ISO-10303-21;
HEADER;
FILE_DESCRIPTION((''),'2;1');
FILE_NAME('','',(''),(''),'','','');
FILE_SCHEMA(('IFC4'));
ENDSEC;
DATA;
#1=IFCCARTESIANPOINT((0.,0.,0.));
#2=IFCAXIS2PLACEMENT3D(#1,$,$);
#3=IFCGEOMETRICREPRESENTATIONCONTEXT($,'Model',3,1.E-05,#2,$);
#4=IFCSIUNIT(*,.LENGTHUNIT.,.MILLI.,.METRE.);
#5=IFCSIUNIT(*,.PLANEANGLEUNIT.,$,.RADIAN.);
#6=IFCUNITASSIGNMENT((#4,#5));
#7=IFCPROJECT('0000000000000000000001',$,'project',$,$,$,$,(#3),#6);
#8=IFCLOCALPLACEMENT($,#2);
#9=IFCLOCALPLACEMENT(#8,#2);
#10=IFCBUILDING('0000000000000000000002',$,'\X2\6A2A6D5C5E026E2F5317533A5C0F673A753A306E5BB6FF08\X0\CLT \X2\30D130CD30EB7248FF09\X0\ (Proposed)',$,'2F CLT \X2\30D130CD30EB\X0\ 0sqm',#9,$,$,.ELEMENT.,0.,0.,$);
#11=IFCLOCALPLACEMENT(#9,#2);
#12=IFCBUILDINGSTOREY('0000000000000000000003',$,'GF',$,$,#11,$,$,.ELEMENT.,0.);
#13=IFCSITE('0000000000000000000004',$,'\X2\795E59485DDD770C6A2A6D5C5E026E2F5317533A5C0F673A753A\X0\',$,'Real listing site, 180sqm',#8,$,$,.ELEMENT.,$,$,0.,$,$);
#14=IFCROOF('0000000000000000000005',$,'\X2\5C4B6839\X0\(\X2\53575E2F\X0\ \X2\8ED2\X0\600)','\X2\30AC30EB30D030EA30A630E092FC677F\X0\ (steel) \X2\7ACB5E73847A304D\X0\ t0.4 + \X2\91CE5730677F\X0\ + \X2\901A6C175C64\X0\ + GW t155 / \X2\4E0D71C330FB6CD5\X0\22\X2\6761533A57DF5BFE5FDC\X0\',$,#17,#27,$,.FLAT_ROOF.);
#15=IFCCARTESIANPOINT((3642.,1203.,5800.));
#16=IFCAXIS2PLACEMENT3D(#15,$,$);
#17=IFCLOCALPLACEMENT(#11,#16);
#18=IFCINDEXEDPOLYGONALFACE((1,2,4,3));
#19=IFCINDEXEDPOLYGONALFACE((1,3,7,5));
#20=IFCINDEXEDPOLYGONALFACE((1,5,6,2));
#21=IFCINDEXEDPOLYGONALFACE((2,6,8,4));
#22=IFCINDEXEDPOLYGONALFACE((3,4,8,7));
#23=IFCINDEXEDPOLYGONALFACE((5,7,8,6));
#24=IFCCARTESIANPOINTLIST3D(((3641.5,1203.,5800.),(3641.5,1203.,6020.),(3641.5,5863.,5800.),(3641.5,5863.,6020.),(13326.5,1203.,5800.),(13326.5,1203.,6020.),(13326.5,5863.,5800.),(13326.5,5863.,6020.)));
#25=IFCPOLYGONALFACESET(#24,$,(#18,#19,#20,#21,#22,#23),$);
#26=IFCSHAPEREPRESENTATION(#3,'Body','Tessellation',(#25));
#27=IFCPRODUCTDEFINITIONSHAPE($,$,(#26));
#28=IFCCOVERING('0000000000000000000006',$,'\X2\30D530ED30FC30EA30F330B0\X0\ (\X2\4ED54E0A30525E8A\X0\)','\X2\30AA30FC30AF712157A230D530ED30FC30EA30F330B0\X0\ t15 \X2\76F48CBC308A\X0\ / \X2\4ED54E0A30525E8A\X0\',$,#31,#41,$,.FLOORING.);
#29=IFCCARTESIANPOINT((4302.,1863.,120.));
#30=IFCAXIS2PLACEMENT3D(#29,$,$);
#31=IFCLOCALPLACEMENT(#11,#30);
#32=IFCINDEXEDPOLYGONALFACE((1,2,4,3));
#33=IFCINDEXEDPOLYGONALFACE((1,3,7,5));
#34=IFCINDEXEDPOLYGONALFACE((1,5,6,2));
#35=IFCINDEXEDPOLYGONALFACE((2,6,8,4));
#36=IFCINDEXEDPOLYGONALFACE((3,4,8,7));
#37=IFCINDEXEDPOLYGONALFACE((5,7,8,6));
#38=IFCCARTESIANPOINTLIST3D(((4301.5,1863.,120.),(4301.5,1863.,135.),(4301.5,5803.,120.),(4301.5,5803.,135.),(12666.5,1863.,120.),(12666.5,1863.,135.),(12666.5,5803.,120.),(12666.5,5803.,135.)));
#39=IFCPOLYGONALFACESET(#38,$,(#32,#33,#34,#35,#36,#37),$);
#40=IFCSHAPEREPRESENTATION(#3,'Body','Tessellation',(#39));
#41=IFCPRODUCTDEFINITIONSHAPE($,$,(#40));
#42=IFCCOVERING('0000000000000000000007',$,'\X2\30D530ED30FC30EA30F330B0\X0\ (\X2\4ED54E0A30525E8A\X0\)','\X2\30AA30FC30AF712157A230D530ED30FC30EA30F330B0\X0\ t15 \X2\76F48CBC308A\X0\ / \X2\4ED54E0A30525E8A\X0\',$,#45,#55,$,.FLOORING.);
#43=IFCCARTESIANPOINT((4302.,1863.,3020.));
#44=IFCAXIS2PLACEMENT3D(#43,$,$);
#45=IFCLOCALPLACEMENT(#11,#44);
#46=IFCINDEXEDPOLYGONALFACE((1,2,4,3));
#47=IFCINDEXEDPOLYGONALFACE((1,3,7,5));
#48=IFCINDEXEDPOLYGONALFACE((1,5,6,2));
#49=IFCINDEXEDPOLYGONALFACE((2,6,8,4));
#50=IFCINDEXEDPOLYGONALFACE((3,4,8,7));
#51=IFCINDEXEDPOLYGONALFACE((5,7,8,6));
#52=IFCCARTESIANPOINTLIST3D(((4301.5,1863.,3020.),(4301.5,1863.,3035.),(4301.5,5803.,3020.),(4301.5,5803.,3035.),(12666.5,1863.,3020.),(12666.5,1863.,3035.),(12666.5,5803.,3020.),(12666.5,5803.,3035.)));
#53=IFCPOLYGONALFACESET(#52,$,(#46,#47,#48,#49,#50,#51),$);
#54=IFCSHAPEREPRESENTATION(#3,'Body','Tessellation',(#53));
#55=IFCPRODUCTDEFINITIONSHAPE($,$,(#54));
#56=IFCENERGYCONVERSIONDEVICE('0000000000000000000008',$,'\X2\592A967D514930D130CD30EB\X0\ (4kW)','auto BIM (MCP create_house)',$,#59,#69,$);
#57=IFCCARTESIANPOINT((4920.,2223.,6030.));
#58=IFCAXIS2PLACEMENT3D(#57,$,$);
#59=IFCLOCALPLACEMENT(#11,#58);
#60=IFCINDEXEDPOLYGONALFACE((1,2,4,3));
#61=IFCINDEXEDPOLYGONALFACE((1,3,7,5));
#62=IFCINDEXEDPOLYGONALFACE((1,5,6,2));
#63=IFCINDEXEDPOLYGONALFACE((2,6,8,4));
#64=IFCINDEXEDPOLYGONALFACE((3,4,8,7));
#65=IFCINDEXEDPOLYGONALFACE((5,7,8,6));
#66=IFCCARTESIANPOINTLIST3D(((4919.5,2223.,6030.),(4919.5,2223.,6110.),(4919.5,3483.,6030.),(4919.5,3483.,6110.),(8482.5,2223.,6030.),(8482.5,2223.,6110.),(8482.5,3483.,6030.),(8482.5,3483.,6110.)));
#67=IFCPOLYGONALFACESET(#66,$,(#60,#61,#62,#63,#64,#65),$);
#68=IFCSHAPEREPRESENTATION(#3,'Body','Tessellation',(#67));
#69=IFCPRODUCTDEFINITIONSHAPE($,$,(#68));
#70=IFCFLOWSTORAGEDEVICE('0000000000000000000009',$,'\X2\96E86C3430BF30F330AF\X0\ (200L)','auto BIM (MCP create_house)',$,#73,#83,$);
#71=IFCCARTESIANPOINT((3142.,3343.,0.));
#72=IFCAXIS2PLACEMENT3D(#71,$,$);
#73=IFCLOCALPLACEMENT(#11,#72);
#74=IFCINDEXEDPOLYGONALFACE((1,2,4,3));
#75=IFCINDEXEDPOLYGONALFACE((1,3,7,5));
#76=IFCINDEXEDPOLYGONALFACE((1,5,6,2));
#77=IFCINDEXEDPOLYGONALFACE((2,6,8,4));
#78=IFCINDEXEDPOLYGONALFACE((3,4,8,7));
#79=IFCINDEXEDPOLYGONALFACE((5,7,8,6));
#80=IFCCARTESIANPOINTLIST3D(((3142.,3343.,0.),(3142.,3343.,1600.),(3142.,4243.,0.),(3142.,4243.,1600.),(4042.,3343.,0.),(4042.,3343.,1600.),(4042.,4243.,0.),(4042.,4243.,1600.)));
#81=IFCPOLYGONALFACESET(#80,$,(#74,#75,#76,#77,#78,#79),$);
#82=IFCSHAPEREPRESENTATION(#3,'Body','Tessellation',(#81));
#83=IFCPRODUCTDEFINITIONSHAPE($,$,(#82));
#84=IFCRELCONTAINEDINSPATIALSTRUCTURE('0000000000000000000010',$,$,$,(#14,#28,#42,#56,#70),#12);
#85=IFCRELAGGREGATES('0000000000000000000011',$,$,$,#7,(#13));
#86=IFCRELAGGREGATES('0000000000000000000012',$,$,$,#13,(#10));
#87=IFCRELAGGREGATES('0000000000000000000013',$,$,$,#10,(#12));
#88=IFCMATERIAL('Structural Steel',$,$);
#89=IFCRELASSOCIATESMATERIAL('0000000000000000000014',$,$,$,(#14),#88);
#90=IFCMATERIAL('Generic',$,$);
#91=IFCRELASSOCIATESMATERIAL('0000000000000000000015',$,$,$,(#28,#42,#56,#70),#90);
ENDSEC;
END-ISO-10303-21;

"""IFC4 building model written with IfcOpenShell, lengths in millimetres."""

from ifc_helpers import new_model, si_unit, frame, frame_2d, origin, place, context, project, spatial, rectangle, extrude, material, element, save


model = new_model("IFC4")

# Units and contexts
model_context = context("Model", 3, precision=1e-05, world=origin())
ifc_project = project(units=[si_unit("LENGTHUNIT", "METRE", prefix="MILLI"), si_unit("PLANEANGLEUNIT", "RADIAN")], contexts=[model_context])

# Site, building, storey
site_placement = place(None, origin())
site = spatial("IfcSite", under=ifc_project, at=site_placement, Name="神奈川県横浜市港北区小机町", ObjectType="Real listing site, 180sqm", CompositionType="ELEMENT", RefElevation=0.0)
building_placement = place(site_placement, origin())
building = spatial("IfcBuilding", under=site, at=building_placement, Name="横浜市港北区小机町の家（CLT パネル版） (Proposed)", ObjectType="2F CLT パネル 0sqm", CompositionType="ELEMENT", ElevationOfRefHeight=0.0, ElevationOfTerrain=0.0)
storey_placement = place(building_placement, origin())
storey = spatial("IfcBuildingStorey", under=building, at=storey_placement, Name="GF", CompositionType="ELEMENT", Elevation=0.0)

# Roof
ifc_material_1 = material(Name="Structural Steel")
for number, where, name in (
    (1, (3642.0, 1203.0, 5800.0), "屋根(南帯 軒600)"),
):
    element("IfcRoof", number, at=place(storey_placement, frame(where)), inside=storey, material=ifc_material_1, Name=name, Description="ガルバリウム鋼板 (steel) 立平葺き t0.4 + 野地板 + 通気層 + GW t155 / 不燃・法22条区域対応", PredefinedType="FLAT_ROOF", context=model_context, shape_type="SweptSolid", body=[
        extrude(rectangle(XDim=9685.0, YDim=4660.0, at=frame_2d((4842.0, 2330.0))), frame((3642.0, 1203.0, 5800.0)), (0.0, 0.0, 1.0), 220.0),
    ])

# Coverings
ifc_material_2 = material(Name="Generic")
covering_1_placement = place(storey_placement, frame((4302.0, 1863.0, 120.0)))
element("IfcCovering", 2, at=covering_1_placement, inside=storey, material=ifc_material_2, Name="フローリング (仕上げ床)", Description="オーク無垢フローリング t15 直貼り / 仕上げ床", PredefinedType="FLOORING", context=model_context, shape_type="SweptSolid", body=[
    extrude(rectangle(XDim=8365.0, YDim=3940.0, at=frame_2d((4182.0, 1970.0))), frame((4302.0, 1863.0, 120.0)), (0.0, 0.0, 1.0), 15.0),
])
covering_2_placement = place(storey_placement, frame((4302.0, 1863.0, 3020.0)))
element("IfcCovering", 3, at=covering_2_placement, inside=storey, material=ifc_material_2, Name="フローリング (仕上げ床)", Description="オーク無垢フローリング t15 直貼り / 仕上げ床", PredefinedType="FLOORING", context=model_context, shape_type="SweptSolid", body=[
    extrude(rectangle(XDim=8365.0, YDim=3940.0, at=frame_2d((4182.0, 1970.0))), frame((4302.0, 1863.0, 3020.0)), (0.0, 0.0, 1.0), 15.0),
])

# Energy conversion device
energy_conversion_device_placement = place(storey_placement, frame((4920.0, 2223.0, 6030.0)))
element("IfcEnergyConversionDevice", 4, at=energy_conversion_device_placement, inside=storey, material=ifc_material_2, Name="太陽光パネル (4kW)", Description="auto BIM (MCP create_house)", context=model_context, shape_type="SweptSolid", body=[
    extrude(rectangle(XDim=3563.0, YDim=1260.0, at=frame_2d((1781.0, 630.0))), frame((4920.0, 2223.0, 6030.0)), (0.0, 0.0, 1.0), 80.0),
])

# Flow storage device
flow_storage_device_placement = place(storey_placement, frame((3142.0, 3343.0, 0.0)))
element("IfcFlowStorageDevice", 5, at=flow_storage_device_placement, inside=storey, material=ifc_material_2, Name="雨水タンク (200L)", Description="auto BIM (MCP create_house)", context=model_context, shape_type="SweptSolid", body=[
    extrude(rectangle(XDim=900.0, YDim=900.0, at=frame_2d((450.0, 450.0))), frame((3142.0, 3343.0, 0.0)), (0.0, 0.0, 1.0), 1600.0),
])

save(model, "model.ifc")
